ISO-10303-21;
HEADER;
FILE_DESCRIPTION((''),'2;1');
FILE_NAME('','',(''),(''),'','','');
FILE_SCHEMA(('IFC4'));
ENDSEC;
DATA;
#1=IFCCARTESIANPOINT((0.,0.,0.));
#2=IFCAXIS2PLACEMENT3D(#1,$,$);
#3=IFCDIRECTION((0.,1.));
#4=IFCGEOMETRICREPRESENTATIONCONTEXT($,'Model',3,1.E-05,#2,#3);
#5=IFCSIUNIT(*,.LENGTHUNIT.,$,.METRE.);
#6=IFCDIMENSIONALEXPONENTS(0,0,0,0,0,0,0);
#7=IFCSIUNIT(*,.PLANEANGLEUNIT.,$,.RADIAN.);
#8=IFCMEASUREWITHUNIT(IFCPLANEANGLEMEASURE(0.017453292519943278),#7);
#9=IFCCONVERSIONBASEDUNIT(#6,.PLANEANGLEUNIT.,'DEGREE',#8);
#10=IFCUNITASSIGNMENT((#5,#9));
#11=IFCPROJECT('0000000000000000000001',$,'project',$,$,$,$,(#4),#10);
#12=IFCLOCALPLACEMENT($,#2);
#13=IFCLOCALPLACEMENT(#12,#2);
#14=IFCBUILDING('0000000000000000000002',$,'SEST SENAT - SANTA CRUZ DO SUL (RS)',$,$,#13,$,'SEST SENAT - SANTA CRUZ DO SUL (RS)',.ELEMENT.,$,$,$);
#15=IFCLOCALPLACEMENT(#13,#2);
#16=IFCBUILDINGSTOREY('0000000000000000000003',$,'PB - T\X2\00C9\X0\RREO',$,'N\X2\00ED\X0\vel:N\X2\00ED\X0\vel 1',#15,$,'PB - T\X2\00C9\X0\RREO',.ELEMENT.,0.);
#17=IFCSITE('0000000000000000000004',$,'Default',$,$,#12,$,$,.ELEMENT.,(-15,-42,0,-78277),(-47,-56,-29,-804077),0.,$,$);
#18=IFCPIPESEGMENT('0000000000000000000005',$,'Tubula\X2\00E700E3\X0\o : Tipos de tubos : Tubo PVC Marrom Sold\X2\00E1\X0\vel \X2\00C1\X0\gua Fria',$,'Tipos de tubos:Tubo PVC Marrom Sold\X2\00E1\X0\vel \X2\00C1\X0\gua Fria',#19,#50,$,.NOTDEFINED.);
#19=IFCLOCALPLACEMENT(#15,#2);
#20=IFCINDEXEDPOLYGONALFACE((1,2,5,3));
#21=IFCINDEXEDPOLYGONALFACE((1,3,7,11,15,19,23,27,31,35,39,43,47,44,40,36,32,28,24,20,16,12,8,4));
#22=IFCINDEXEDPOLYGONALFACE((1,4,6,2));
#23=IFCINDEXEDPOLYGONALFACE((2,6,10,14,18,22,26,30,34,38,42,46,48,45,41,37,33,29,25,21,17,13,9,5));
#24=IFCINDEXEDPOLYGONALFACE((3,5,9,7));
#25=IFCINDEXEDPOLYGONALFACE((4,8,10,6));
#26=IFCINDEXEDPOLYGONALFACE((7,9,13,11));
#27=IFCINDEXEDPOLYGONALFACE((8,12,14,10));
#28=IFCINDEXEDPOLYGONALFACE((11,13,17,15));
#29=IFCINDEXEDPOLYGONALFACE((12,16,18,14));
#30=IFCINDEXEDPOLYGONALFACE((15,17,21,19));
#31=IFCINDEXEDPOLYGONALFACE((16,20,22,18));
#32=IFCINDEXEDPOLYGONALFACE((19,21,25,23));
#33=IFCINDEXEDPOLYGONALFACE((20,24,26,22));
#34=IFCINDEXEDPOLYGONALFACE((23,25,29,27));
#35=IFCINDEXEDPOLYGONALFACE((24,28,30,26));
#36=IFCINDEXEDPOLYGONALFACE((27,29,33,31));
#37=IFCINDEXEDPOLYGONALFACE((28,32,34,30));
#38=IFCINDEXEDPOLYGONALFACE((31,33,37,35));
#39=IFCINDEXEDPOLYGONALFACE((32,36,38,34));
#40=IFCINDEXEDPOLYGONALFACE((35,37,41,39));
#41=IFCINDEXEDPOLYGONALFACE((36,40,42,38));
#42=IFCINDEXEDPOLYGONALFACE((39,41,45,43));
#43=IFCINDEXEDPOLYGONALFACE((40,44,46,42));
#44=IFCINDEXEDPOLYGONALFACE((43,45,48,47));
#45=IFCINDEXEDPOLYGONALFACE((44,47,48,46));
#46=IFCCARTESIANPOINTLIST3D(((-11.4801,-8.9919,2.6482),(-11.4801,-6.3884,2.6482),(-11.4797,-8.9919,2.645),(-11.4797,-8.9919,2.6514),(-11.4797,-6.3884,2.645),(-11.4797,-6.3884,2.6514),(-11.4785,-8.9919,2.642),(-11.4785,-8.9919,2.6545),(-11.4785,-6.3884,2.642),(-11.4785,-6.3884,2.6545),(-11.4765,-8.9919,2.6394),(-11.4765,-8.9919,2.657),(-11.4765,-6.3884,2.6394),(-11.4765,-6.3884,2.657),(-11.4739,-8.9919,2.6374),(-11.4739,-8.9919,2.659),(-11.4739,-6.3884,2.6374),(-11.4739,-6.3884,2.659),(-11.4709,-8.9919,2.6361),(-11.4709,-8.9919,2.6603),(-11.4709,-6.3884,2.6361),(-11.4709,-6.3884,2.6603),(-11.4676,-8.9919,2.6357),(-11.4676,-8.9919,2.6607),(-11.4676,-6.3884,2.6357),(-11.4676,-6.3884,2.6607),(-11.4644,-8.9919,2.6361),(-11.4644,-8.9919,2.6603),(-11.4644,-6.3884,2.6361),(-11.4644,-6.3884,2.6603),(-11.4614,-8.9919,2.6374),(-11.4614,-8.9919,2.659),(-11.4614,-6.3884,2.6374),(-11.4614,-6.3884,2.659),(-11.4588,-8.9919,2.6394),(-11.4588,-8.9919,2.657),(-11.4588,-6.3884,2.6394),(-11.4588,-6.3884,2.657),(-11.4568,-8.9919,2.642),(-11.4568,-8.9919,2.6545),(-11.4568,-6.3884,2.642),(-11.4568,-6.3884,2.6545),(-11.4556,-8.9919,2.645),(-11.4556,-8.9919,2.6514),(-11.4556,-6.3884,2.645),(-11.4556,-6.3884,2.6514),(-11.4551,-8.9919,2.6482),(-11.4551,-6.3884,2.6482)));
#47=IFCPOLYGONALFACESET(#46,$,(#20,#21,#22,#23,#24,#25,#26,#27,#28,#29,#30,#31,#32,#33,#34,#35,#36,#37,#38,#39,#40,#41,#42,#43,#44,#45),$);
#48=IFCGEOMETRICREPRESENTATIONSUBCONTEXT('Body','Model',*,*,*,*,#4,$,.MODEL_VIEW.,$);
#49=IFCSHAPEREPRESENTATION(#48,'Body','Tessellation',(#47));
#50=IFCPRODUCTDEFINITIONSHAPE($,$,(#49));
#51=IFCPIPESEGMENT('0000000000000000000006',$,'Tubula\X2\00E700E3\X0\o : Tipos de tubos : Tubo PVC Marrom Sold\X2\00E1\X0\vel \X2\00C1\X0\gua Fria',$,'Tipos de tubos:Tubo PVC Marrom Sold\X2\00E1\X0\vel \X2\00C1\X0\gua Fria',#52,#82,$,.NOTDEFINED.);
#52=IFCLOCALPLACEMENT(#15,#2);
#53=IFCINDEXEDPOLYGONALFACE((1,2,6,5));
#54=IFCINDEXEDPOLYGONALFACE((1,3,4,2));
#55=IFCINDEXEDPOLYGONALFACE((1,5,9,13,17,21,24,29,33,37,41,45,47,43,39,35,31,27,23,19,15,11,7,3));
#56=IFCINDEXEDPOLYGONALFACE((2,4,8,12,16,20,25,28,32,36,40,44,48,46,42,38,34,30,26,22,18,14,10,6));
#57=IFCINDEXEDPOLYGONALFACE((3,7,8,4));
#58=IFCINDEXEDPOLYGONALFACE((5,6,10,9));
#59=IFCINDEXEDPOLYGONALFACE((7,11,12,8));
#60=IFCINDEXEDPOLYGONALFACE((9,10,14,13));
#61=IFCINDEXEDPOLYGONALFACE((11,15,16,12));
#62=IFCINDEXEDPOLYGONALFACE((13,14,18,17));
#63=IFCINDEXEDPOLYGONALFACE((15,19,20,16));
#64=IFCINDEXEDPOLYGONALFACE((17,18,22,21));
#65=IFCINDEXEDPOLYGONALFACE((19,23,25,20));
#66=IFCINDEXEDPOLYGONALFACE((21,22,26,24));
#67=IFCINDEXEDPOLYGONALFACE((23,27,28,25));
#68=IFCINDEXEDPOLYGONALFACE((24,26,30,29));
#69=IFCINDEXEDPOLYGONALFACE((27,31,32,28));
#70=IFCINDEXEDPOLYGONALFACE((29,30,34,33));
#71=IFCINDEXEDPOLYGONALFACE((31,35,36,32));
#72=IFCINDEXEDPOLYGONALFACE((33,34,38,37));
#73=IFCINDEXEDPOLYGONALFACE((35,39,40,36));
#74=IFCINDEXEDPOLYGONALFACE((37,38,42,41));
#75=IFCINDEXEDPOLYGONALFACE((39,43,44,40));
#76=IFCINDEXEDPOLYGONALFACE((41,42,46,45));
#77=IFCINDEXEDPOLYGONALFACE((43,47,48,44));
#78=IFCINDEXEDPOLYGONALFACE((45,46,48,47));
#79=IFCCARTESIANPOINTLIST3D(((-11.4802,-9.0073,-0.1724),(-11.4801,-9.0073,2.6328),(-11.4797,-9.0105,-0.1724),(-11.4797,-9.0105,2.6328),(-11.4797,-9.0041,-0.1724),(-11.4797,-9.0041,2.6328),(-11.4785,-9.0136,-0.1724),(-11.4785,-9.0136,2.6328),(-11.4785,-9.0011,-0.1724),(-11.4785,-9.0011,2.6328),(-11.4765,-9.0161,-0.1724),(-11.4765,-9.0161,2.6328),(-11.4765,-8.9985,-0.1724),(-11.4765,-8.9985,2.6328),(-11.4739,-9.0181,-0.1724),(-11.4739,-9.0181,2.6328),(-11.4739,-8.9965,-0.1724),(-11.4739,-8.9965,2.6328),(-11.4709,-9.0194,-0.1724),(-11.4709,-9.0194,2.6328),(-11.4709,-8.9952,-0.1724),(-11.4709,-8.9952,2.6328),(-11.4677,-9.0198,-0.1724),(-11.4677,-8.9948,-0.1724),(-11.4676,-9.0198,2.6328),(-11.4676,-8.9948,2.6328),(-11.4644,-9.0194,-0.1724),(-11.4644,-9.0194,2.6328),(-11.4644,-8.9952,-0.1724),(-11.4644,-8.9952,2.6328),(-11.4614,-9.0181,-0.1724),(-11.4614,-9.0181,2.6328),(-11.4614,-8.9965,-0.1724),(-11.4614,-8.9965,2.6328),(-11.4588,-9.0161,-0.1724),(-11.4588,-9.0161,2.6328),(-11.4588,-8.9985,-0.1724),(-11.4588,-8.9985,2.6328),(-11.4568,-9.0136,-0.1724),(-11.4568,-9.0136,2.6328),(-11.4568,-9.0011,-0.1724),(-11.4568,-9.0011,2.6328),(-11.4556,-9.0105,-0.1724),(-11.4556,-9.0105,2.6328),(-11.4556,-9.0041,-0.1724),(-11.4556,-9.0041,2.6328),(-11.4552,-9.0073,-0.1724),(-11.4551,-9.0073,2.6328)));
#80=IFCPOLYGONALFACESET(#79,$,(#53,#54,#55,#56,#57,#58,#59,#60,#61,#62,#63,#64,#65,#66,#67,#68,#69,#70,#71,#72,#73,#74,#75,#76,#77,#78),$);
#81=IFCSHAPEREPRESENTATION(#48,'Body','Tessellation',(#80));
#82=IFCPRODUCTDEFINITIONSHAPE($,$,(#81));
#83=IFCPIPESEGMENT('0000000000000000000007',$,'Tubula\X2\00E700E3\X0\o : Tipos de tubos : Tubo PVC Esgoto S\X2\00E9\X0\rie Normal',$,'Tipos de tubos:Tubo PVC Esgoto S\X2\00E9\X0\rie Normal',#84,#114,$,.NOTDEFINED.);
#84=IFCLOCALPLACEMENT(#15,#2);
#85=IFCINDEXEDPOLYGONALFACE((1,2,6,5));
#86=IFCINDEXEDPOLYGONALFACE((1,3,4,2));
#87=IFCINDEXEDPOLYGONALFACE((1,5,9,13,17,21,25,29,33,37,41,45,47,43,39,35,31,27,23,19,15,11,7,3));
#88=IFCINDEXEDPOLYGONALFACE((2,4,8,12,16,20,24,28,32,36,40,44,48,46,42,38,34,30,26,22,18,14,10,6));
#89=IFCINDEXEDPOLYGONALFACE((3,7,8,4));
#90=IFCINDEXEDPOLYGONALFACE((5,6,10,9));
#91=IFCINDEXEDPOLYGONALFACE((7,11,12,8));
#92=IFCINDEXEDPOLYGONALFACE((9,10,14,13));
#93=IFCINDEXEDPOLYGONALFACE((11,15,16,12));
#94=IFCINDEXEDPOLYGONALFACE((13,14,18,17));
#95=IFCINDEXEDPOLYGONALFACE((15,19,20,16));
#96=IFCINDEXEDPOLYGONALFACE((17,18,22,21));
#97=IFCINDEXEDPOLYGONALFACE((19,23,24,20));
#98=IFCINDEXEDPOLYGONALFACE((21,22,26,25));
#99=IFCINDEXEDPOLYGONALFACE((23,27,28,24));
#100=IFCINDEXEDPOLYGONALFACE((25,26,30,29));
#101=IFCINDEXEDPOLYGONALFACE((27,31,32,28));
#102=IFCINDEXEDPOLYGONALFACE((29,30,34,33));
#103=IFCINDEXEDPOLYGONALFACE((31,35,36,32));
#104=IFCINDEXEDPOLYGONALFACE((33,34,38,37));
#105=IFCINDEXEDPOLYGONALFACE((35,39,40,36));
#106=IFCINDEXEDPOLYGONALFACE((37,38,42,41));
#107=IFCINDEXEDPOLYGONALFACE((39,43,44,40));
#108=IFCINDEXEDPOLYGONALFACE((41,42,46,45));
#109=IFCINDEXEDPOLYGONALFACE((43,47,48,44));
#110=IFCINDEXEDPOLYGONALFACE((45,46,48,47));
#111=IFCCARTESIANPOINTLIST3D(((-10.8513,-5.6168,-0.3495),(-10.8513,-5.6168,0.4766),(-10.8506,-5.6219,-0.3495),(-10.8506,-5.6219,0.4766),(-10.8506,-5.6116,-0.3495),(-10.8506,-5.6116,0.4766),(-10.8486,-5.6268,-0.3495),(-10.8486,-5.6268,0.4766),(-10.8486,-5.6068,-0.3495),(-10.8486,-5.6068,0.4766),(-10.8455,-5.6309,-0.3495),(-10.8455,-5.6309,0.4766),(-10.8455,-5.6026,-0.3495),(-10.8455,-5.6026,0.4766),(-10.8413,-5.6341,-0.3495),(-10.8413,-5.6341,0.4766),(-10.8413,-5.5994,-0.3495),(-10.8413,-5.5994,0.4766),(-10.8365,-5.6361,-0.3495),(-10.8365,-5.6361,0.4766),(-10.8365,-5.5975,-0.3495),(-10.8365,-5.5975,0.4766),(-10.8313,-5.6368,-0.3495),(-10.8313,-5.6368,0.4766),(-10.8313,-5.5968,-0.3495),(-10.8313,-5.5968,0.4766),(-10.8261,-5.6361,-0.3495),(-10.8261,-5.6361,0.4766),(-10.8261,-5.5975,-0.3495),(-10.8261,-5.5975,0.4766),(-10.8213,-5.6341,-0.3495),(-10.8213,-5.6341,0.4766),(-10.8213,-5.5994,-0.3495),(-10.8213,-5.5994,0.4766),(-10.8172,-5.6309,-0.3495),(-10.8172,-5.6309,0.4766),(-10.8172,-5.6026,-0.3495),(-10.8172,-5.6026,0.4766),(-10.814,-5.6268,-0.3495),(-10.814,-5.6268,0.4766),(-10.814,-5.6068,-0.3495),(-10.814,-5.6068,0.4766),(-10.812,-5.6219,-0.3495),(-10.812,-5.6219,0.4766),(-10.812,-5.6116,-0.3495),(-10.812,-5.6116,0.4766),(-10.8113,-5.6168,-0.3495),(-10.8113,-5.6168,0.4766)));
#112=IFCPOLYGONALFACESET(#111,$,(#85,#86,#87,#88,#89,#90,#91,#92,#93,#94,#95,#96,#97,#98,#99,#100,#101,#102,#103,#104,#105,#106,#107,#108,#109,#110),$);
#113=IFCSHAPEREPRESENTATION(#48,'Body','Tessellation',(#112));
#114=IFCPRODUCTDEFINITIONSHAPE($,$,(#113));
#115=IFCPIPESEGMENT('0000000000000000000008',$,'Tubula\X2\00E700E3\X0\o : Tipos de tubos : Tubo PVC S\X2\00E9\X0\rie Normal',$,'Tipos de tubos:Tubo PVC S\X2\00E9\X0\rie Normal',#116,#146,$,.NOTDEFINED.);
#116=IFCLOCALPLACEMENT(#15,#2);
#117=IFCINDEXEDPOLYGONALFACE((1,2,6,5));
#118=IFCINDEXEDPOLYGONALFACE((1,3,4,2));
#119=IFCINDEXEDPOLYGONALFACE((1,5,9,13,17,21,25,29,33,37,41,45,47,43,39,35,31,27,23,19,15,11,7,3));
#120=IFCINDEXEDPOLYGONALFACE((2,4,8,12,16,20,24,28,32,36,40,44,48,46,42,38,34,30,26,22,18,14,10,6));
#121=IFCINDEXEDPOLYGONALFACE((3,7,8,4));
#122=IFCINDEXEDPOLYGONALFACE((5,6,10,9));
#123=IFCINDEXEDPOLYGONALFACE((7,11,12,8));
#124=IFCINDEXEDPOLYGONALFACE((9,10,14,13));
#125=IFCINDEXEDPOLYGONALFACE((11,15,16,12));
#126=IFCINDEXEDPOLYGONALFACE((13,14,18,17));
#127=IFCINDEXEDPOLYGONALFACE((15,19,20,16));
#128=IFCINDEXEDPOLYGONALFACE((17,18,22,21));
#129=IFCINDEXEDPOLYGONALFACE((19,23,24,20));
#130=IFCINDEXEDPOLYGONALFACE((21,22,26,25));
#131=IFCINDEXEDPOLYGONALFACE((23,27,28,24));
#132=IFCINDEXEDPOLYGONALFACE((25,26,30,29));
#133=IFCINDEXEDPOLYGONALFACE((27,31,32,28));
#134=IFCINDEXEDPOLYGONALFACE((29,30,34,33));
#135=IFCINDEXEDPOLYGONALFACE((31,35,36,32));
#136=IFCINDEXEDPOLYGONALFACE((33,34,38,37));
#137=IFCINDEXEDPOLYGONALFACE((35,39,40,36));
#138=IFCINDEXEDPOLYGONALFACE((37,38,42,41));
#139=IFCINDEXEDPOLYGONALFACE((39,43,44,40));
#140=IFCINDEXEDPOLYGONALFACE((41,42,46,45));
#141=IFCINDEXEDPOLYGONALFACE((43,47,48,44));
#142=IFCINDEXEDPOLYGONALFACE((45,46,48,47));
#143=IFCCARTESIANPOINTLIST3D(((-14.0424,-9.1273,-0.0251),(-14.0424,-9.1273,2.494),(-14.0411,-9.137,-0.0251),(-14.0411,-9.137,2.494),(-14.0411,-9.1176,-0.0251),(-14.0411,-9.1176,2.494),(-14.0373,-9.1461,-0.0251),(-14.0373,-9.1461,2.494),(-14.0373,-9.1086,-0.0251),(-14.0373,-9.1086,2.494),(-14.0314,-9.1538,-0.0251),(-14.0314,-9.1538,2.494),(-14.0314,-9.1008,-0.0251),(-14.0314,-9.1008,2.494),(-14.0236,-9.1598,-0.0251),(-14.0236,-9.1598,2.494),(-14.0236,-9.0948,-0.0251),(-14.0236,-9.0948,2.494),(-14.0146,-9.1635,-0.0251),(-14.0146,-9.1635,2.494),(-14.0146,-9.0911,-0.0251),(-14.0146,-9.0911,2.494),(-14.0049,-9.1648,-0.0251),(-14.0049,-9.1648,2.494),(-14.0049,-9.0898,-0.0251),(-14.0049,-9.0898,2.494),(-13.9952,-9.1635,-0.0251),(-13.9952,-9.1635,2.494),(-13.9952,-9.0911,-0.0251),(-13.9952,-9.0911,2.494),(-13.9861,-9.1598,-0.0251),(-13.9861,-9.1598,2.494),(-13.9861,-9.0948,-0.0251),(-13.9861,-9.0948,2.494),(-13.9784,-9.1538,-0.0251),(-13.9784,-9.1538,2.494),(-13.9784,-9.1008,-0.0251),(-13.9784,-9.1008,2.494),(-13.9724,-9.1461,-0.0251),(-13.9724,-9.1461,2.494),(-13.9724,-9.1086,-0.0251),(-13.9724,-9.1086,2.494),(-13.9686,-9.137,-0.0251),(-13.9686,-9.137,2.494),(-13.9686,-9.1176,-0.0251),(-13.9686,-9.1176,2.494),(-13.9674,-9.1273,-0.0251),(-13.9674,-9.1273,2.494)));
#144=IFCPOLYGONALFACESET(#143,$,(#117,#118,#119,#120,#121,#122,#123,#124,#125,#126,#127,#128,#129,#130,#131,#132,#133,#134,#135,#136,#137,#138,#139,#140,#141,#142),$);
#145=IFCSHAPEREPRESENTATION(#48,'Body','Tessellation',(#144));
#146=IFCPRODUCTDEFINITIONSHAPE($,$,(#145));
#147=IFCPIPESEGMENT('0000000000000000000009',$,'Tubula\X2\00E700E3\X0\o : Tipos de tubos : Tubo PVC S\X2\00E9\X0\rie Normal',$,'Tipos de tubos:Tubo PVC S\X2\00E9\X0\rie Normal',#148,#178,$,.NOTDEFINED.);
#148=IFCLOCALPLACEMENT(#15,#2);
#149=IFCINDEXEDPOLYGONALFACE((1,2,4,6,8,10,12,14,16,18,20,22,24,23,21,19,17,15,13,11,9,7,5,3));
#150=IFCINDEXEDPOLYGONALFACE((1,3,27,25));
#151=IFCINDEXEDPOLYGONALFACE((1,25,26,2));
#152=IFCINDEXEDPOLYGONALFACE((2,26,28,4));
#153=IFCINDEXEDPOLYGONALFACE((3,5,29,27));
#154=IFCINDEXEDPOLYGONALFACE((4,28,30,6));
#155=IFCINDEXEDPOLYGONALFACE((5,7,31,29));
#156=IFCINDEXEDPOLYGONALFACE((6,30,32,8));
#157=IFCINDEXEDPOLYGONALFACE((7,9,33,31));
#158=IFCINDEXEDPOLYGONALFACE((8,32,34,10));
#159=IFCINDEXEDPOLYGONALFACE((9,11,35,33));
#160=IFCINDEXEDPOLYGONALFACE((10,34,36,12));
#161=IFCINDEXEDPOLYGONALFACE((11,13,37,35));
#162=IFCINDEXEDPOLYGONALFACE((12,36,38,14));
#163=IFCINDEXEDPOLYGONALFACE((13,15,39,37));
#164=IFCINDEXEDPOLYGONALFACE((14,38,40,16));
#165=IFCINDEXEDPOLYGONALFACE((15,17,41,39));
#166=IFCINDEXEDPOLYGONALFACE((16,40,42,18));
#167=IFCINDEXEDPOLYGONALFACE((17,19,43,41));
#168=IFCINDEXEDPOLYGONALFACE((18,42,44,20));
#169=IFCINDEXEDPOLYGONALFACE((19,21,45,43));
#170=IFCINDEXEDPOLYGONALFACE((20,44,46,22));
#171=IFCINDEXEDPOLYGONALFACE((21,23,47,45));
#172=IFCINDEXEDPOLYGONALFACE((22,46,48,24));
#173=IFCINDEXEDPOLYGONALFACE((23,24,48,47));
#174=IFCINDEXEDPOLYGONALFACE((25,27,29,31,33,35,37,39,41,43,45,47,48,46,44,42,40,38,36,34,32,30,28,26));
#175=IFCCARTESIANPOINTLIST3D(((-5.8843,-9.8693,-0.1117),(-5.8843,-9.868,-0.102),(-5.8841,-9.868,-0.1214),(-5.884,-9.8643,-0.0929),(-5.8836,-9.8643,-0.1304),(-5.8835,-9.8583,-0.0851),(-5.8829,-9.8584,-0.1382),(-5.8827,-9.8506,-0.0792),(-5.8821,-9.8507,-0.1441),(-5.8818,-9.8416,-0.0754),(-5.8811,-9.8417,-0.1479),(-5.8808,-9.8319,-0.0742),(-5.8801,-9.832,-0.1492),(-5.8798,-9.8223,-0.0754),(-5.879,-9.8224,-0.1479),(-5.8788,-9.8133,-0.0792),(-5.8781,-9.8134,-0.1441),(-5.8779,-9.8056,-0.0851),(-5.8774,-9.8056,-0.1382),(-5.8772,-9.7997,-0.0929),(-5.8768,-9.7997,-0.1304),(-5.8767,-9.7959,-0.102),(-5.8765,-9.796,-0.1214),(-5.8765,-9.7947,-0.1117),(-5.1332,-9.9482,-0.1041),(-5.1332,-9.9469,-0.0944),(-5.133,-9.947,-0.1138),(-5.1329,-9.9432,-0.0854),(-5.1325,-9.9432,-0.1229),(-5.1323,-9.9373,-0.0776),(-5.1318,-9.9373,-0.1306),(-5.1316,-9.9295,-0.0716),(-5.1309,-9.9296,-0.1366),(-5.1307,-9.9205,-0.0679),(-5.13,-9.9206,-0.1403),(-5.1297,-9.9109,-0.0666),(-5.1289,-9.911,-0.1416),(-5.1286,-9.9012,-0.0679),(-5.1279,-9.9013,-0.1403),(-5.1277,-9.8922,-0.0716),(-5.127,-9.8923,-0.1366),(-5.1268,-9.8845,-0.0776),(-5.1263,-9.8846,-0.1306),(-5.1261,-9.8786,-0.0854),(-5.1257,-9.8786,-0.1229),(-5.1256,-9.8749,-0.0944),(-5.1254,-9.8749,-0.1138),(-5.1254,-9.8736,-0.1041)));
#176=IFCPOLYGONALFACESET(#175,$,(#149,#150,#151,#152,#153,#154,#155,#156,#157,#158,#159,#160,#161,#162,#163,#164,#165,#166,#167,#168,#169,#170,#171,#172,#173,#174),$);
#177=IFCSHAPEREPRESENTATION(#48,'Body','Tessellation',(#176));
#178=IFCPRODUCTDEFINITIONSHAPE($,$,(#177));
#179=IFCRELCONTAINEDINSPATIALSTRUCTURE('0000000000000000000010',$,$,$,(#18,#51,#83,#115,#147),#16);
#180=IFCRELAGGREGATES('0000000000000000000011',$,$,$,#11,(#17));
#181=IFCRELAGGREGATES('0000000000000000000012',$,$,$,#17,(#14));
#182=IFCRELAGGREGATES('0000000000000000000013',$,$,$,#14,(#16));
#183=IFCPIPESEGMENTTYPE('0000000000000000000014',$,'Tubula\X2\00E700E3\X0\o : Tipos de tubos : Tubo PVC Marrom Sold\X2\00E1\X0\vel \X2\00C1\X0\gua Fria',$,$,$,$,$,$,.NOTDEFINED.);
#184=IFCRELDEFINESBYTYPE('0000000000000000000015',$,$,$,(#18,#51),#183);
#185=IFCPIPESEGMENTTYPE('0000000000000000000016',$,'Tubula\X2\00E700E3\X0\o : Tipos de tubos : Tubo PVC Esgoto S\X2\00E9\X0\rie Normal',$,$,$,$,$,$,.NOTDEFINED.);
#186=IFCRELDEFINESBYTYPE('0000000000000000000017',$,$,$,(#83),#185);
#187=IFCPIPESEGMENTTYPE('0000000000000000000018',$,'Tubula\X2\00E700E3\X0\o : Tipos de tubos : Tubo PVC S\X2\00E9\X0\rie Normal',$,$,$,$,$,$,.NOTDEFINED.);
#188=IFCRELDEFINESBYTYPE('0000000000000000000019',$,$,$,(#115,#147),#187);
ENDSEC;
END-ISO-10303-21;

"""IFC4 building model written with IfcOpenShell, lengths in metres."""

from ifc_helpers import new_model, entity, si_unit, converted_unit, direction, frame, origin, place, context, subcontext, project, spatial, arc, indexed_curve, outline, extrude, type_object, element, save


model = new_model("IFC4")

# Units and contexts
model_context = context("Model", 3, precision=1e-05, world=origin(), true_north=direction((0.0, 1.0)))
body_context = subcontext(model_context, "Body", "Model", "MODEL_VIEW")
ifc_project = project(units=[si_unit("LENGTHUNIT", "METRE"), converted_unit("PLANEANGLEUNIT", "DEGREE", entity("IfcPlaneAngleMeasure", 0.017453292519943278), si_unit("PLANEANGLEUNIT", "RADIAN"), dimensions=[0, 0, 0, 0, 0, 0, 0])], contexts=[model_context])

# Site, building, storey
site_placement = place(None, origin())
site = spatial("IfcSite", under=ifc_project, at=site_placement, Name="Default", CompositionType="ELEMENT", RefLatitude=(-15, -42, 0, -78277), RefLongitude=(-47, -56, -29, -804077), RefElevation=0.0)
building_placement = place(site_placement, origin())
building = spatial("IfcBuilding", under=site, at=building_placement, Name="SEST SENAT - SANTA CRUZ DO SUL (RS)", LongName="SEST SENAT - SANTA CRUZ DO SUL (RS)", CompositionType="ELEMENT")
storey_placement = place(building_placement, origin())
storey = spatial("IfcBuildingStorey", under=building, at=storey_placement, Name="PB - TÉRREO", ObjectType="Nível:Nível 1", LongName="PB - TÉRREO", CompositionType="ELEMENT", Elevation=0.0)

# Pipe segments
pipe_segment_type_1 = type_object("IfcPipeSegmentType", Name="Tubulação : Tipos de tubos : Tubo PVC Marrom Soldável Água Fria", PredefinedType="NOTDEFINED")
pipe_segment_1_placement = place(storey_placement, frame((-11.4817, -8.9919, 2.6623)))
element("IfcPipeSegment", 1, at=pipe_segment_1_placement, inside=storey, type_object=pipe_segment_type_1, Name="Tubulação : Tipos de tubos : Tubo PVC Marrom Soldável Água Fria", ObjectType="Tipos de tubos:Tubo PVC Marrom Soldável Água Fria", PredefinedType="NOTDEFINED", context=body_context, shape_type="SweptSolid", body=[
    extrude(outline(indexed_curve([(0.0125, 0.0), (0.0088, 0.0088), (0.0, 0.0125), (-0.0088, 0.0088), (-0.0125, 0.0), (-0.0088, -0.0088), (0.0, -0.0125), (0.0088, -0.0088)], segments=[arc(1, 2, 3), arc(3, 4, 5), arc(5, 6, 7), arc(7, 8, 1)], self_intersect=False)), frame((0.0141, 0.0, -0.0141), z_axis=(0.0, 1.0, 0.0), x_axis=(1.0, 0.0, 0.0)), (0.0, 0.0, 1.0), 2.6035),
])
pipe_segment_2_placement = place(storey_placement, frame((-11.4818, -9.0214, -0.1724)))
element("IfcPipeSegment", 2, at=pipe_segment_2_placement, inside=storey, type_object=pipe_segment_type_1, Name="Tubulação : Tipos de tubos : Tubo PVC Marrom Soldável Água Fria", ObjectType="Tipos de tubos:Tubo PVC Marrom Soldável Água Fria", PredefinedType="NOTDEFINED", context=body_context, shape_type="SweptSolid", body=[
    extrude(outline(indexed_curve([(0.0125, 0.0), (0.0088, 0.0088), (0.0, 0.0125), (-0.0088, 0.0088), (-0.0125, 0.0), (-0.0088, -0.0088), (0.0, -0.0125), (0.0088, -0.0088)], segments=[arc(1, 2, 3), arc(3, 4, 5), arc(5, 6, 7), arc(7, 8, 1)], self_intersect=False)), frame((0.0141, 0.0141, 0.0), z_axis=(0.000007, 0.0, 1.0), x_axis=(-1.0, 0.0, 0.000007)), (0.0, 0.0, 1.0), 2.8052),
])
pipe_segment_type_2 = type_object("IfcPipeSegmentType", Name="Tubulação : Tipos de tubos : Tubo PVC Esgoto Série Normal", PredefinedType="NOTDEFINED")
pipe_segment_3_placement = place(storey_placement, frame((-10.8529, -5.6384, -0.3495)))
element("IfcPipeSegment", 3, at=pipe_segment_3_placement, inside=storey, type_object=pipe_segment_type_2, Name="Tubulação : Tipos de tubos : Tubo PVC Esgoto Série Normal", ObjectType="Tipos de tubos:Tubo PVC Esgoto Série Normal", PredefinedType="NOTDEFINED", context=body_context, shape_type="SweptSolid", body=[
    extrude(outline(indexed_curve([(0.02, 0.0), (0.0141, 0.0141), (0.0, 0.02), (-0.0141, 0.0141), (-0.02, 0.0), (-0.0141, -0.0141), (0.0, -0.02), (0.0141, -0.0141)], segments=[arc(1, 2, 3), arc(3, 4, 5), arc(5, 6, 7), arc(7, 8, 1)], self_intersect=False)), frame((0.0216, 0.0216, 0.0), z_axis=(0.0, 0.0, 1.0), x_axis=(-1.0, 0.0, 0.0)), (0.0, 0.0, 1.0), 0.8262),
])
pipe_segment_type_3 = type_object("IfcPipeSegmentType", Name="Tubulação : Tipos de tubos : Tubo PVC Série Normal", PredefinedType="NOTDEFINED")
pipe_segment_4_placement = place(storey_placement, frame((-14.044, -9.1664, -0.0251)))
element("IfcPipeSegment", 4, at=pipe_segment_4_placement, inside=storey, type_object=pipe_segment_type_3, Name="Tubulação : Tipos de tubos : Tubo PVC Série Normal", ObjectType="Tipos de tubos:Tubo PVC Série Normal", PredefinedType="NOTDEFINED", context=body_context, shape_type="SweptSolid", body=[
    extrude(outline(indexed_curve([(0.0375, 0.0), (0.0265, 0.0265), (0.0, 0.0375), (-0.0265, 0.0265), (-0.0375, 0.0), (-0.0265, -0.0265), (0.0, -0.0375), (0.0265, -0.0265)], segments=[arc(1, 2, 3), arc(3, 4, 5), arc(5, 6, 7), arc(7, 8, 1)], self_intersect=False)), frame((0.0391, 0.0391, 0.0)), (0.0, 0.0, 1.0), 2.5191),
])
pipe_segment_5_placement = place(storey_placement, frame((-5.8859, -9.9498, -0.1507)))
element("IfcPipeSegment", 5, at=pipe_segment_5_placement, inside=storey, type_object=pipe_segment_type_3, Name="Tubulação : Tipos de tubos : Tubo PVC Série Normal", ObjectType="Tipos de tubos:Tubo PVC Série Normal", PredefinedType="NOTDEFINED", context=body_context, shape_type="SweptSolid", body=[
    extrude(outline(indexed_curve([(0.0375, 0.0), (0.0265, 0.0265), (0.0, 0.0375), (-0.0265, 0.0265), (-0.0375, 0.0), (-0.0265, -0.0265), (0.0, -0.0375), (0.0265, -0.0265)], segments=[arc(1, 2, 3), arc(3, 4, 5), arc(5, 6, 7), arc(7, 8, 1)], self_intersect=False)), frame((0.7566, 0.0389, 0.0466), z_axis=(-0.994473, 0.104518, -0.01), x_axis=(-0.104523, -0.994522, 0.0)), (0.0, 0.0, 1.0), 0.7553),
])

save(model, "model.ifc")
